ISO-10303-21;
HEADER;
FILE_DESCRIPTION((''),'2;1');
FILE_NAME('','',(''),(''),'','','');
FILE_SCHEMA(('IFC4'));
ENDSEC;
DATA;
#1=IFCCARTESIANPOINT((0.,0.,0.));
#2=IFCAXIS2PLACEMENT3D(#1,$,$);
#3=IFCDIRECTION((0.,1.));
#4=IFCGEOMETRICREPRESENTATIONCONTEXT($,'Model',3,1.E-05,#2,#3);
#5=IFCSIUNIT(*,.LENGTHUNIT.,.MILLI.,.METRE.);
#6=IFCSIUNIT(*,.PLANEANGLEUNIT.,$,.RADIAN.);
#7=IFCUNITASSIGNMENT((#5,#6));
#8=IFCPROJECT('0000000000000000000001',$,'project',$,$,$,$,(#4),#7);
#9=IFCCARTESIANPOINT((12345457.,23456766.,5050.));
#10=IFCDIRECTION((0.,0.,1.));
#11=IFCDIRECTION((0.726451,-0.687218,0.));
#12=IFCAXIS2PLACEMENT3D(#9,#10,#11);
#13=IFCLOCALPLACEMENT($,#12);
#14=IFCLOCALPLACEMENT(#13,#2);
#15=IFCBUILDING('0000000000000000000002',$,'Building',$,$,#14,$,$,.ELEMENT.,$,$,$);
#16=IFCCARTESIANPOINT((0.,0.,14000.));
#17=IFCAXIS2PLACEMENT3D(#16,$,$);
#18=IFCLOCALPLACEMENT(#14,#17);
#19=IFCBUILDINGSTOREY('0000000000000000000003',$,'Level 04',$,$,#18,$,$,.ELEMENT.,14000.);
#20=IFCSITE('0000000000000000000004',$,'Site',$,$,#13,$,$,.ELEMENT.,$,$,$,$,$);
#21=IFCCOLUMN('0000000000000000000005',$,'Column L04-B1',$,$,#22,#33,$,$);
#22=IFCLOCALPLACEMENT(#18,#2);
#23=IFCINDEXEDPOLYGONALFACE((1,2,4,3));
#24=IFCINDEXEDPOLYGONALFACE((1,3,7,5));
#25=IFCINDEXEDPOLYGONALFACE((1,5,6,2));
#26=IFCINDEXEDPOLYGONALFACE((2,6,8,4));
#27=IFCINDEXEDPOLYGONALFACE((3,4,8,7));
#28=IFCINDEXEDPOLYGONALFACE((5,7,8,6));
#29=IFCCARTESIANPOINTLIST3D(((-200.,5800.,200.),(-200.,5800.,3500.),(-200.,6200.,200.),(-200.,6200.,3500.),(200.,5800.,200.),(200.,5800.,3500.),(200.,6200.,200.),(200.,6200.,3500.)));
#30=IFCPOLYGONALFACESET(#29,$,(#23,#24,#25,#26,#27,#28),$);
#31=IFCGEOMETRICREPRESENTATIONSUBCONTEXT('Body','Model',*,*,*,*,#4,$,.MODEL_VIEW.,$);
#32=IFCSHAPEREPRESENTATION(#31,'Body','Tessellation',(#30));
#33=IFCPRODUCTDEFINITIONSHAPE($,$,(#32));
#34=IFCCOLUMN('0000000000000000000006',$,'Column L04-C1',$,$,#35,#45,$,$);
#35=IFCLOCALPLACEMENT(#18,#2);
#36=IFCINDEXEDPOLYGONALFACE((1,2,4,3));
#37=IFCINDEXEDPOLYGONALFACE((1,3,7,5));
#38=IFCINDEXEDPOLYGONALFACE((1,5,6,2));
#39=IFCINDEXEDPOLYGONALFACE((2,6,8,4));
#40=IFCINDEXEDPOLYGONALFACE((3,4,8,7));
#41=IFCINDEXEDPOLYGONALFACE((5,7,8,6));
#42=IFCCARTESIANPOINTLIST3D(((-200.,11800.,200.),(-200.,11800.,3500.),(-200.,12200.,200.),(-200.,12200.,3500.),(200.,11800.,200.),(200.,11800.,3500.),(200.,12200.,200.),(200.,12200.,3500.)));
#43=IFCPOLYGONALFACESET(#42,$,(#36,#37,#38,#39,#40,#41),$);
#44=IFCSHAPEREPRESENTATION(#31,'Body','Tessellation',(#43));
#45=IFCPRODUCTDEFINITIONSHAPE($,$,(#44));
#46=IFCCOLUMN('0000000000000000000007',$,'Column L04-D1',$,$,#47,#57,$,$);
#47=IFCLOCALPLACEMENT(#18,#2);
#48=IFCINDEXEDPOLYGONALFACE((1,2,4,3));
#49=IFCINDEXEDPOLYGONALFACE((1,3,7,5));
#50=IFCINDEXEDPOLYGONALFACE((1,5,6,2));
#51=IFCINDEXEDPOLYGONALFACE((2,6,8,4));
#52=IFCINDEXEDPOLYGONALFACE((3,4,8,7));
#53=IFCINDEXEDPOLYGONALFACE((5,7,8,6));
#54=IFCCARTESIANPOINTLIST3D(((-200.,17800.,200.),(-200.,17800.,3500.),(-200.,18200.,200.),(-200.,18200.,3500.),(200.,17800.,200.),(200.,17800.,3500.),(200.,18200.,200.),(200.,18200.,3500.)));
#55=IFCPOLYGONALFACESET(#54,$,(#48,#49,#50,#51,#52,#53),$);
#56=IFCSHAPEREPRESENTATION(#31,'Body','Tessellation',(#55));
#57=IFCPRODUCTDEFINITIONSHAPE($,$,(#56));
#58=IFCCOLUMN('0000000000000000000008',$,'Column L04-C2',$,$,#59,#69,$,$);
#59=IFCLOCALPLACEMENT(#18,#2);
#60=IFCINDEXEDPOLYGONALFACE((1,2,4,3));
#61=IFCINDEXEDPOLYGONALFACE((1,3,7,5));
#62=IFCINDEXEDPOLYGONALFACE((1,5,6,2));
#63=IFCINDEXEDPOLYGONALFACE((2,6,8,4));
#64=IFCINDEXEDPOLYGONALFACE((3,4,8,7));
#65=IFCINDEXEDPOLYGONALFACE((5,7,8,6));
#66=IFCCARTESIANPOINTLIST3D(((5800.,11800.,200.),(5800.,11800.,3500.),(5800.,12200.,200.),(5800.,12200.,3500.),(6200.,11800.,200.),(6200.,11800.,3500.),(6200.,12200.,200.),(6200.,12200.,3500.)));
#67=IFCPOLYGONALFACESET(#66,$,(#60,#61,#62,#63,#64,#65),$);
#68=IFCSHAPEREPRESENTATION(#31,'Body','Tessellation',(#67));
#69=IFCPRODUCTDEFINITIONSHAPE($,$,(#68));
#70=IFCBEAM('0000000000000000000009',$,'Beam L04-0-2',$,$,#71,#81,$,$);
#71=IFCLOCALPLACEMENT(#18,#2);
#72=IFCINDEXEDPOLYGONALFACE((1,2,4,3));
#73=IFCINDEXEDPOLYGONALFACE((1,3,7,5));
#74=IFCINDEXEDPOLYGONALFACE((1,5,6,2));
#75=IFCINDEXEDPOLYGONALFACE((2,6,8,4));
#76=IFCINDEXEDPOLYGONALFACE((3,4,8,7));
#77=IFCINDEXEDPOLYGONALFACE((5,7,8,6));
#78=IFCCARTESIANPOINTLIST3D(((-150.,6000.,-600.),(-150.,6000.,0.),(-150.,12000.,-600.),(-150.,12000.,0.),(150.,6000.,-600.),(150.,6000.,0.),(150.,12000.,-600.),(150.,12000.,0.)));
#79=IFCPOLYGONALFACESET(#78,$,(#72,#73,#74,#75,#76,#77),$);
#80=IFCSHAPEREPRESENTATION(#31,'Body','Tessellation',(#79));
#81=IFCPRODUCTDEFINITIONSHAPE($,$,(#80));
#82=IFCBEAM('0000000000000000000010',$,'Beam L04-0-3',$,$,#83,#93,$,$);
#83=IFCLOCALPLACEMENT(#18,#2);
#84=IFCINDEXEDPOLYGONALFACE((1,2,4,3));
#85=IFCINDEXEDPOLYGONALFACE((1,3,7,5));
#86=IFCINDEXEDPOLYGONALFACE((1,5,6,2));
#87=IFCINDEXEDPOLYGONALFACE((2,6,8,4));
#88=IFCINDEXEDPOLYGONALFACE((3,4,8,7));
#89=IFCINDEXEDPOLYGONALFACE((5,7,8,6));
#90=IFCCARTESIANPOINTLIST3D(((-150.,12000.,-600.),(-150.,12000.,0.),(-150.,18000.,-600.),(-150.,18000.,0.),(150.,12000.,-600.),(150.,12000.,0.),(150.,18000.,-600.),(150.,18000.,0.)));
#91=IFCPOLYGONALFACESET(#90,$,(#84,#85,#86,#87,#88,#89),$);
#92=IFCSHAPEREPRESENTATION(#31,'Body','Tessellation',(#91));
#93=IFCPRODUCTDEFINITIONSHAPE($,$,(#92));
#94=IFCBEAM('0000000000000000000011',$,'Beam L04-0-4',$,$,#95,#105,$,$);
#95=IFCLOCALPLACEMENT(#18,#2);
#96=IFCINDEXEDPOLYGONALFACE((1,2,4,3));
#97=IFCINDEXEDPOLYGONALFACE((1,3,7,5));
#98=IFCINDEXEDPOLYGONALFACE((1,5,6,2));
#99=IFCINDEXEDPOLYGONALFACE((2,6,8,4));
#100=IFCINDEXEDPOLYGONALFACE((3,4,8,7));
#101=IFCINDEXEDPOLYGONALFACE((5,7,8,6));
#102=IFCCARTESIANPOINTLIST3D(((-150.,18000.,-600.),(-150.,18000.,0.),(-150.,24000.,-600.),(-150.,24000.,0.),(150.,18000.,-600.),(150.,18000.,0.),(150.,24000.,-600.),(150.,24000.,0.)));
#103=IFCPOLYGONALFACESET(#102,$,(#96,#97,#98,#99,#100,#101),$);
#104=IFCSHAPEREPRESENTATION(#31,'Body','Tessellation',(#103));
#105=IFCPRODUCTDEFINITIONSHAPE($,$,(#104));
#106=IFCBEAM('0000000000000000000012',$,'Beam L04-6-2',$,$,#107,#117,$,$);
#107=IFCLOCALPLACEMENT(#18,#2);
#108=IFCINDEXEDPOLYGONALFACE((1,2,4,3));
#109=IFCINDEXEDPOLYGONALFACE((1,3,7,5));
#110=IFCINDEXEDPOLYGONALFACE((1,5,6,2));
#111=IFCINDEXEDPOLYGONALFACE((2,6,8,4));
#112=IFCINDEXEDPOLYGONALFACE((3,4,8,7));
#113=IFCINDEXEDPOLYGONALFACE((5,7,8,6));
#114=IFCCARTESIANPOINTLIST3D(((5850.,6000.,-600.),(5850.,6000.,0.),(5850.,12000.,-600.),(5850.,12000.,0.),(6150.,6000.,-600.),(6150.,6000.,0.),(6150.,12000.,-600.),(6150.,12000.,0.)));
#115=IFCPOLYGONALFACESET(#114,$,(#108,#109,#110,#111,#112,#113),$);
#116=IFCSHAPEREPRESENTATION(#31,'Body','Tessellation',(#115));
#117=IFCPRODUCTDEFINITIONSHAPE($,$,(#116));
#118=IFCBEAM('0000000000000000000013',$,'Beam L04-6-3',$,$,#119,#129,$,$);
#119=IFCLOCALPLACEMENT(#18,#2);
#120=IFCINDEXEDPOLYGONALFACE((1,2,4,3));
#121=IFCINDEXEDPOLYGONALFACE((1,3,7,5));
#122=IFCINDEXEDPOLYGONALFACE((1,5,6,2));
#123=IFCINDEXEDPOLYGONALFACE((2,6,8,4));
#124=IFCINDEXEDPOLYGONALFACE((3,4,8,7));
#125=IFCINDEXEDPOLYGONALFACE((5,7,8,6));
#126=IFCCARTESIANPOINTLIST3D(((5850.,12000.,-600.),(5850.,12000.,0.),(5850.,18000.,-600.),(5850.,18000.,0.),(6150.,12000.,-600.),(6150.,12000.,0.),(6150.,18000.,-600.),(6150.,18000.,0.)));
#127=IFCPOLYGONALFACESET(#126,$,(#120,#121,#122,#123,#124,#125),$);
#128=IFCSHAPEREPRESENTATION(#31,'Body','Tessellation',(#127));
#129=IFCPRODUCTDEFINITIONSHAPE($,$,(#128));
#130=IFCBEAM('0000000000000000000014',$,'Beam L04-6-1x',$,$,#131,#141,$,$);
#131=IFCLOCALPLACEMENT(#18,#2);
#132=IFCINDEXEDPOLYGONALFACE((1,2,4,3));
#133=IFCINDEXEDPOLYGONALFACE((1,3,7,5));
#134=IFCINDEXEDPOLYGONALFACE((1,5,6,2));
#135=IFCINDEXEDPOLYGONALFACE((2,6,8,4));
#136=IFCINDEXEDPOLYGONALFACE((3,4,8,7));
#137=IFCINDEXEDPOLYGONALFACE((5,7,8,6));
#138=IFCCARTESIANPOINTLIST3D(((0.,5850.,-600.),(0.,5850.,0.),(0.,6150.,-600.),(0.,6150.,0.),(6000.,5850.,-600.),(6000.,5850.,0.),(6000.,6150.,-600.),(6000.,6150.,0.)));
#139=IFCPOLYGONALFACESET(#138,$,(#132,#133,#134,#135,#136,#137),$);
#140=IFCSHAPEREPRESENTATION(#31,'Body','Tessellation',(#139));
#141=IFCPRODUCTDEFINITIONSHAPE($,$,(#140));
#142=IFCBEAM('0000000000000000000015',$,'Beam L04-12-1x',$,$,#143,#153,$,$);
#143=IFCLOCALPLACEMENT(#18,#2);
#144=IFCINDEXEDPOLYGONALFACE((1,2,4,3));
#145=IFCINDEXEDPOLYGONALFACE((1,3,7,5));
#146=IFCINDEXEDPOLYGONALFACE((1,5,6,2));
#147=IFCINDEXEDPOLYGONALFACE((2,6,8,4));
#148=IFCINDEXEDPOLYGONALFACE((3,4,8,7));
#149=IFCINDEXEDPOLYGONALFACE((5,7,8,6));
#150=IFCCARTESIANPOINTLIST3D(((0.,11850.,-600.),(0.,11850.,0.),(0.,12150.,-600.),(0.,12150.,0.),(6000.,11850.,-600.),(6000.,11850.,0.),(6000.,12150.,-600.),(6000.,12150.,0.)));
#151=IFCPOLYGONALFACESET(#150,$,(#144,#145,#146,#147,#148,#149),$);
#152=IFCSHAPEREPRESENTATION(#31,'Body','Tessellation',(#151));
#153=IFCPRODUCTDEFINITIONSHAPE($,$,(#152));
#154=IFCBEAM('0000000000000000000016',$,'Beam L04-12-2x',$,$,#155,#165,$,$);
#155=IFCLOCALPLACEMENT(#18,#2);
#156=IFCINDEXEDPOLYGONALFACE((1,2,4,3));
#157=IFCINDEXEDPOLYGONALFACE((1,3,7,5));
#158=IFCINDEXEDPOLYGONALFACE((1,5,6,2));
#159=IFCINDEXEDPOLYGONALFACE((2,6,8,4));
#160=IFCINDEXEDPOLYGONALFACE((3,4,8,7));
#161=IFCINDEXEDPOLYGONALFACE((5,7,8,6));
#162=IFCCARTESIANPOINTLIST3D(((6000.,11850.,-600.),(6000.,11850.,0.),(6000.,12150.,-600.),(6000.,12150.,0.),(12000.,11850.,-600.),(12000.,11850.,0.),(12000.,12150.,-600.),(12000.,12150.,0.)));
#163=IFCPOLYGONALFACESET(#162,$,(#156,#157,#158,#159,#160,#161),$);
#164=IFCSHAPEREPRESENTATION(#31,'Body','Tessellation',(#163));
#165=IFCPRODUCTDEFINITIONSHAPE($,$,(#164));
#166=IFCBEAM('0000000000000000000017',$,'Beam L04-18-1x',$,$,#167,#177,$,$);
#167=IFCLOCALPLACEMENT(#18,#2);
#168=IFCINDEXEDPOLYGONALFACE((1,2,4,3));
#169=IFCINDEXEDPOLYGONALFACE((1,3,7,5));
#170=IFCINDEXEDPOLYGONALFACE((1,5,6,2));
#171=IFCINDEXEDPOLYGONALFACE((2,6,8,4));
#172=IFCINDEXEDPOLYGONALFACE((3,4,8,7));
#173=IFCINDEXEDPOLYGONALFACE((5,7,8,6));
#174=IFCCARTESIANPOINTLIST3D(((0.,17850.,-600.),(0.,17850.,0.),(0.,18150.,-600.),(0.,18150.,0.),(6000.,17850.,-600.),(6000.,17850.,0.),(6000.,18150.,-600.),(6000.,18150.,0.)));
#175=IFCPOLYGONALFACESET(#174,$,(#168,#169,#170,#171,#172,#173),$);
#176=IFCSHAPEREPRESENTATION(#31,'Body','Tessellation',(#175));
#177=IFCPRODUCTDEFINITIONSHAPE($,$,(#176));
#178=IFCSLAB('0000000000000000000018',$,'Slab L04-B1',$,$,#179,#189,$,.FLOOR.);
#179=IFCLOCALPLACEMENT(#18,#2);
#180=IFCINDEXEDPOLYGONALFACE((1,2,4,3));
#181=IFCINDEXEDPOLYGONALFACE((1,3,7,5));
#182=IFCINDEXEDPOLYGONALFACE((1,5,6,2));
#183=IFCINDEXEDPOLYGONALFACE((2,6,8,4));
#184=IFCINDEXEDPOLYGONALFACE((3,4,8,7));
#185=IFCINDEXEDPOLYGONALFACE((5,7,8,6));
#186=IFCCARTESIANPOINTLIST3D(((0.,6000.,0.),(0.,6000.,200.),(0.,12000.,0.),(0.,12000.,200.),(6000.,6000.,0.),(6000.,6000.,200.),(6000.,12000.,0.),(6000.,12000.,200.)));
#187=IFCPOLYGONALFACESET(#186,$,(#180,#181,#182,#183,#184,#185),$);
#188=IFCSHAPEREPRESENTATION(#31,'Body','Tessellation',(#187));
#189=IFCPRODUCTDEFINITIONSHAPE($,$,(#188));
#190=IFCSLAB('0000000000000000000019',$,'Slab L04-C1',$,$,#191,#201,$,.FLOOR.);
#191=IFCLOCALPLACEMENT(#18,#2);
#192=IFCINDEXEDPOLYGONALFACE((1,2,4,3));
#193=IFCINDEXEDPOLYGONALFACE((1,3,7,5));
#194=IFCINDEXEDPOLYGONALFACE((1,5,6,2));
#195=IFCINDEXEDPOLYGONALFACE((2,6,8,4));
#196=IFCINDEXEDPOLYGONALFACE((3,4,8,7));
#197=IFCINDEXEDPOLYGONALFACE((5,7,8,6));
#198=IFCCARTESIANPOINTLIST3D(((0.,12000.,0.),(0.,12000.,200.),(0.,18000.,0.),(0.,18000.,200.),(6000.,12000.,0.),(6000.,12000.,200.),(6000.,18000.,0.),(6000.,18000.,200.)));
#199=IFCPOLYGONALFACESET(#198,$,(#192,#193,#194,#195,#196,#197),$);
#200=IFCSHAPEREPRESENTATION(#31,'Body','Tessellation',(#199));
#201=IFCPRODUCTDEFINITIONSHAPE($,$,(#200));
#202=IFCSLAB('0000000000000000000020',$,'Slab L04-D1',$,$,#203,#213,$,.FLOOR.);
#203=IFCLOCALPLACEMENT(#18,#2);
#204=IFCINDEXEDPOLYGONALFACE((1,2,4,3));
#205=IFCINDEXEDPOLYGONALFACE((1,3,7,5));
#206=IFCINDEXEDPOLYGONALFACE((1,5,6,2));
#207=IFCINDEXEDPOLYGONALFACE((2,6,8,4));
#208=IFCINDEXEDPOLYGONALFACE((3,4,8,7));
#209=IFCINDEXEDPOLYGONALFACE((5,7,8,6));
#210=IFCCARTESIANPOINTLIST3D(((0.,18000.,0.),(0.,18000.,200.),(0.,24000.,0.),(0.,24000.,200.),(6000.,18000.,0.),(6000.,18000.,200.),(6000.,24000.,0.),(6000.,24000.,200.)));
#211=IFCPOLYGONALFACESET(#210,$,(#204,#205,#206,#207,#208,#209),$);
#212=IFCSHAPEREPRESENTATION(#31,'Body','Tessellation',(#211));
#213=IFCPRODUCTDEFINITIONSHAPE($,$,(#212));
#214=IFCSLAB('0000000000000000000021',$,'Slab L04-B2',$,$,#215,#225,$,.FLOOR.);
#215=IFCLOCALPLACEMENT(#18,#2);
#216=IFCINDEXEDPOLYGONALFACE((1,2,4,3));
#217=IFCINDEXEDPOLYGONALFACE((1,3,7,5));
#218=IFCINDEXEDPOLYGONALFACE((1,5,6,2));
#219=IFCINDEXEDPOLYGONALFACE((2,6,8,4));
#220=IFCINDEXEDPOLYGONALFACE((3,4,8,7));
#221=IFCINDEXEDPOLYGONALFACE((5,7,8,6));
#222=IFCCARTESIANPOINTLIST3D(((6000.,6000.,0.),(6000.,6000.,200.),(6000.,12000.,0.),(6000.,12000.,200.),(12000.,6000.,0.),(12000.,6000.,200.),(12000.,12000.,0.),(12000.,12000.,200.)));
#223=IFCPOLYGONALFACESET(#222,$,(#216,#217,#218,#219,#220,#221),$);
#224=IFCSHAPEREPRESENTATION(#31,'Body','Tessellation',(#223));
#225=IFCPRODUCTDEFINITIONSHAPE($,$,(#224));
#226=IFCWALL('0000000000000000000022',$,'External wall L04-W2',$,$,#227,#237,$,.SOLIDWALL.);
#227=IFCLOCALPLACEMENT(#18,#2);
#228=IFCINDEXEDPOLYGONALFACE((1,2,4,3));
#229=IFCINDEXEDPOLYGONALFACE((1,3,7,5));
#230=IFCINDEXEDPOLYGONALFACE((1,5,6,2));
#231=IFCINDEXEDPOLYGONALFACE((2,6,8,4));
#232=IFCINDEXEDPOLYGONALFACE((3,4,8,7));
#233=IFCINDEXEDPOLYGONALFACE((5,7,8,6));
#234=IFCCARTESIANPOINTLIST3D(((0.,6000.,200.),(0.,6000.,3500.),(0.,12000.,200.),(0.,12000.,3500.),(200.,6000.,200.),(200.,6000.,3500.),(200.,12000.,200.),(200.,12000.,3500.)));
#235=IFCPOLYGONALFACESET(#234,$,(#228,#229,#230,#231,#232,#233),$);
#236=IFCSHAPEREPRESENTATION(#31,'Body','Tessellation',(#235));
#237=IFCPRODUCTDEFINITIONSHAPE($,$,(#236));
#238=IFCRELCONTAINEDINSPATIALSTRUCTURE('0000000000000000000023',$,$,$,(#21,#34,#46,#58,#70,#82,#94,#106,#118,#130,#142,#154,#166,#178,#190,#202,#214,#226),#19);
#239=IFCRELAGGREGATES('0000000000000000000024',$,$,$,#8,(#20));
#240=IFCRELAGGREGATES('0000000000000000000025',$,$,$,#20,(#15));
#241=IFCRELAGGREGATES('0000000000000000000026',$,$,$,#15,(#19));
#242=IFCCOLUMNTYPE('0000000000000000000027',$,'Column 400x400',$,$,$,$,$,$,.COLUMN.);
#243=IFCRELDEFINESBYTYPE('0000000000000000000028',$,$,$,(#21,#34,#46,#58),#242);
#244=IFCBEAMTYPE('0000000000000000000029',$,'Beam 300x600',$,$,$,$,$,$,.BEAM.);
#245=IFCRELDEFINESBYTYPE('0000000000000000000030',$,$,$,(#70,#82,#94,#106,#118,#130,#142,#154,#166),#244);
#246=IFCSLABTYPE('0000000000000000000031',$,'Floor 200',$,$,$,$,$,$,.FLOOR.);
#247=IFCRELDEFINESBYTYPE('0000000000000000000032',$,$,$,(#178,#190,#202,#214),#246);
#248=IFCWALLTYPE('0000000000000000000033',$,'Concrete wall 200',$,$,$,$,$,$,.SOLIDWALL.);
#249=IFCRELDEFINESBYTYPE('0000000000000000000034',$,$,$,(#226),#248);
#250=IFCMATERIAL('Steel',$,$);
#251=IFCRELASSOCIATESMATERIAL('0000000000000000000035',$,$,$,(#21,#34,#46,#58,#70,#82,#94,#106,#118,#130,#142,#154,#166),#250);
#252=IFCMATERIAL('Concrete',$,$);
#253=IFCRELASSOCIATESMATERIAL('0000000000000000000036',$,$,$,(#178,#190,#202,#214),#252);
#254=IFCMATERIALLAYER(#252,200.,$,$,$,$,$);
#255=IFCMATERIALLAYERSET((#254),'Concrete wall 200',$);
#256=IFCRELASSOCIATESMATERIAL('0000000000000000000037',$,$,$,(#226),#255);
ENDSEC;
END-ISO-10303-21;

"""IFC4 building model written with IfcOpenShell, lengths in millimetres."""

from ifc_helpers import new_model, si_unit, direction, frame, origin, place, context, subcontext, project, spatial, rectangle, extrude, material, layer, layer_set, layer_usage, type_object, element, save


model = new_model("IFC4")

# Units and contexts
model_context = context("Model", 3, precision=1e-05, world=origin(), true_north=direction((0.0, 1.0)))
body_context = subcontext(model_context, "Body", "Model", "MODEL_VIEW")
ifc_project = project(units=[si_unit("LENGTHUNIT", "METRE", prefix="MILLI"), si_unit("PLANEANGLEUNIT", "RADIAN")], contexts=[model_context])

# Site, building, storey
site_placement = place(None, frame((12345457.0, 23456766.0, 5050.0), z_axis=(0.0, 0.0, 1.0), x_axis=(0.726451, -0.687218, 0.0)))
site = spatial("IfcSite", under=ifc_project, at=site_placement, Name="Site", CompositionType="ELEMENT")
building_placement = place(site_placement, origin())
building = spatial("IfcBuilding", under=site, at=building_placement, Name="Building", CompositionType="ELEMENT")
storey_placement = place(building_placement, frame((0.0, 0.0, 14000.0)))
storey = spatial("IfcBuildingStorey", under=building, at=storey_placement, Name="Level 04", CompositionType="ELEMENT", Elevation=14000.0)

# Columns
ifc_material_1 = material(Name="Steel")
column_type = type_object("IfcColumnType", Name="Column 400x400", PredefinedType="COLUMN")
for number, where, name in (
    (1, (-200.0, 5800.0, 200.0), "Column L04-B1"),
    (2, (-200.0, 11800.0, 200.0), "Column L04-C1"),
    (3, (-200.0, 17800.0, 200.0), "Column L04-D1"),
    (4, (5800.0, 11800.0, 200.0), "Column L04-C2"),
):
    element("IfcColumn", number, at=place(storey_placement, frame(where)), inside=storey, type_object=column_type, material=ifc_material_1, Name=name, context=body_context, shape_type="SweptSolid", body=[
        extrude(rectangle(XDim=400.0, YDim=400.0), frame((200.0, 200.0, 0.0)), (0.0, 0.0, 1.0), 3300.0),
    ])

# Beams
beam_type = type_object("IfcBeamType", Name="Beam 300x600", PredefinedType="BEAM")
for number, where, name in (
    (5, (-150.0, 6000.0, -600.0), "Beam L04-0-2"),
    (6, (-150.0, 12000.0, -600.0), "Beam L04-0-3"),
    (7, (-150.0, 18000.0, -600.0), "Beam L04-0-4"),
    (8, (5850.0, 6000.0, -600.0), "Beam L04-6-2"),
    (9, (5850.0, 12000.0, -600.0), "Beam L04-6-3"),
):
    element("IfcBeam", number, at=place(storey_placement, frame(where)), inside=storey, type_object=beam_type, material=ifc_material_1, Name=name, context=body_context, shape_type="SweptSolid", body=[
        extrude(rectangle(XDim=300.0, YDim=6000.0), frame((150.0, 3000.0, 0.0)), (0.0, 0.0, 1.0), 600.0),
    ])
for number, where, name in (
    (10, (0.0, 5850.0, -600.0), "Beam L04-6-1x"),
    (11, (0.0, 11850.0, -600.0), "Beam L04-12-1x"),
    (12, (6000.0, 11850.0, -600.0), "Beam L04-12-2x"),
    (13, (0.0, 17850.0, -600.0), "Beam L04-18-1x"),
):
    element("IfcBeam", number, at=place(storey_placement, frame(where)), inside=storey, type_object=beam_type, material=ifc_material_1, Name=name, context=body_context, shape_type="SweptSolid", body=[
        extrude(rectangle(XDim=6000.0, YDim=300.0), frame((3000.0, 150.0, 0.0)), (0.0, 0.0, 1.0), 600.0),
    ])

# Slabs
ifc_material_2 = material(Name="Concrete")
slab_type = type_object("IfcSlabType", Name="Floor 200", PredefinedType="FLOOR")
for number, where, name in (
    (14, (0.0, 6000.0, 0.0), "Slab L04-B1"),
    (15, (0.0, 12000.0, 0.0), "Slab L04-C1"),
    (16, (0.0, 18000.0, 0.0), "Slab L04-D1"),
    (17, (6000.0, 6000.0, 0.0), "Slab L04-B2"),
):
    element("IfcSlab", number, at=place(storey_placement, frame(where)), inside=storey, type_object=slab_type, material=ifc_material_2, Name=name, PredefinedType="FLOOR", context=body_context, shape_type="SweptSolid", body=[
        extrude(rectangle(XDim=6000.0, YDim=6000.0), frame((3000.0, 3000.0, 0.0)), (0.0, 0.0, 1.0), 200.0),
    ])

# Wall
ifc_layer_1 = layer(ifc_material_2, 200.0)
ifc_layer_set_1 = layer_set([ifc_layer_1], Name="Concrete wall 200")
ifc_layer_usage_1 = layer_usage(ifc_layer_set_1, "AXIS2", "POSITIVE", 0.0)
wall_type_1 = type_object("IfcWallType", Name="Concrete wall 200", PredefinedType="SOLIDWALL")
for number, where, name in (
    (18, (0.0, 6000.0, 200.0), "External wall L04-W2"),
):
    element("IfcWall", number, at=place(storey_placement, frame(where)), inside=storey, type_object=wall_type_1, material=ifc_layer_usage_1, Name=name, PredefinedType="SOLIDWALL", context=body_context, shape_type="SweptSolid", body=[
        extrude(rectangle(XDim=200.0, YDim=6000.0), frame((100.0, 3000.0, 0.0)), (0.0, 0.0, 1.0), 3300.0),
    ])

save(model, "model.ifc")
